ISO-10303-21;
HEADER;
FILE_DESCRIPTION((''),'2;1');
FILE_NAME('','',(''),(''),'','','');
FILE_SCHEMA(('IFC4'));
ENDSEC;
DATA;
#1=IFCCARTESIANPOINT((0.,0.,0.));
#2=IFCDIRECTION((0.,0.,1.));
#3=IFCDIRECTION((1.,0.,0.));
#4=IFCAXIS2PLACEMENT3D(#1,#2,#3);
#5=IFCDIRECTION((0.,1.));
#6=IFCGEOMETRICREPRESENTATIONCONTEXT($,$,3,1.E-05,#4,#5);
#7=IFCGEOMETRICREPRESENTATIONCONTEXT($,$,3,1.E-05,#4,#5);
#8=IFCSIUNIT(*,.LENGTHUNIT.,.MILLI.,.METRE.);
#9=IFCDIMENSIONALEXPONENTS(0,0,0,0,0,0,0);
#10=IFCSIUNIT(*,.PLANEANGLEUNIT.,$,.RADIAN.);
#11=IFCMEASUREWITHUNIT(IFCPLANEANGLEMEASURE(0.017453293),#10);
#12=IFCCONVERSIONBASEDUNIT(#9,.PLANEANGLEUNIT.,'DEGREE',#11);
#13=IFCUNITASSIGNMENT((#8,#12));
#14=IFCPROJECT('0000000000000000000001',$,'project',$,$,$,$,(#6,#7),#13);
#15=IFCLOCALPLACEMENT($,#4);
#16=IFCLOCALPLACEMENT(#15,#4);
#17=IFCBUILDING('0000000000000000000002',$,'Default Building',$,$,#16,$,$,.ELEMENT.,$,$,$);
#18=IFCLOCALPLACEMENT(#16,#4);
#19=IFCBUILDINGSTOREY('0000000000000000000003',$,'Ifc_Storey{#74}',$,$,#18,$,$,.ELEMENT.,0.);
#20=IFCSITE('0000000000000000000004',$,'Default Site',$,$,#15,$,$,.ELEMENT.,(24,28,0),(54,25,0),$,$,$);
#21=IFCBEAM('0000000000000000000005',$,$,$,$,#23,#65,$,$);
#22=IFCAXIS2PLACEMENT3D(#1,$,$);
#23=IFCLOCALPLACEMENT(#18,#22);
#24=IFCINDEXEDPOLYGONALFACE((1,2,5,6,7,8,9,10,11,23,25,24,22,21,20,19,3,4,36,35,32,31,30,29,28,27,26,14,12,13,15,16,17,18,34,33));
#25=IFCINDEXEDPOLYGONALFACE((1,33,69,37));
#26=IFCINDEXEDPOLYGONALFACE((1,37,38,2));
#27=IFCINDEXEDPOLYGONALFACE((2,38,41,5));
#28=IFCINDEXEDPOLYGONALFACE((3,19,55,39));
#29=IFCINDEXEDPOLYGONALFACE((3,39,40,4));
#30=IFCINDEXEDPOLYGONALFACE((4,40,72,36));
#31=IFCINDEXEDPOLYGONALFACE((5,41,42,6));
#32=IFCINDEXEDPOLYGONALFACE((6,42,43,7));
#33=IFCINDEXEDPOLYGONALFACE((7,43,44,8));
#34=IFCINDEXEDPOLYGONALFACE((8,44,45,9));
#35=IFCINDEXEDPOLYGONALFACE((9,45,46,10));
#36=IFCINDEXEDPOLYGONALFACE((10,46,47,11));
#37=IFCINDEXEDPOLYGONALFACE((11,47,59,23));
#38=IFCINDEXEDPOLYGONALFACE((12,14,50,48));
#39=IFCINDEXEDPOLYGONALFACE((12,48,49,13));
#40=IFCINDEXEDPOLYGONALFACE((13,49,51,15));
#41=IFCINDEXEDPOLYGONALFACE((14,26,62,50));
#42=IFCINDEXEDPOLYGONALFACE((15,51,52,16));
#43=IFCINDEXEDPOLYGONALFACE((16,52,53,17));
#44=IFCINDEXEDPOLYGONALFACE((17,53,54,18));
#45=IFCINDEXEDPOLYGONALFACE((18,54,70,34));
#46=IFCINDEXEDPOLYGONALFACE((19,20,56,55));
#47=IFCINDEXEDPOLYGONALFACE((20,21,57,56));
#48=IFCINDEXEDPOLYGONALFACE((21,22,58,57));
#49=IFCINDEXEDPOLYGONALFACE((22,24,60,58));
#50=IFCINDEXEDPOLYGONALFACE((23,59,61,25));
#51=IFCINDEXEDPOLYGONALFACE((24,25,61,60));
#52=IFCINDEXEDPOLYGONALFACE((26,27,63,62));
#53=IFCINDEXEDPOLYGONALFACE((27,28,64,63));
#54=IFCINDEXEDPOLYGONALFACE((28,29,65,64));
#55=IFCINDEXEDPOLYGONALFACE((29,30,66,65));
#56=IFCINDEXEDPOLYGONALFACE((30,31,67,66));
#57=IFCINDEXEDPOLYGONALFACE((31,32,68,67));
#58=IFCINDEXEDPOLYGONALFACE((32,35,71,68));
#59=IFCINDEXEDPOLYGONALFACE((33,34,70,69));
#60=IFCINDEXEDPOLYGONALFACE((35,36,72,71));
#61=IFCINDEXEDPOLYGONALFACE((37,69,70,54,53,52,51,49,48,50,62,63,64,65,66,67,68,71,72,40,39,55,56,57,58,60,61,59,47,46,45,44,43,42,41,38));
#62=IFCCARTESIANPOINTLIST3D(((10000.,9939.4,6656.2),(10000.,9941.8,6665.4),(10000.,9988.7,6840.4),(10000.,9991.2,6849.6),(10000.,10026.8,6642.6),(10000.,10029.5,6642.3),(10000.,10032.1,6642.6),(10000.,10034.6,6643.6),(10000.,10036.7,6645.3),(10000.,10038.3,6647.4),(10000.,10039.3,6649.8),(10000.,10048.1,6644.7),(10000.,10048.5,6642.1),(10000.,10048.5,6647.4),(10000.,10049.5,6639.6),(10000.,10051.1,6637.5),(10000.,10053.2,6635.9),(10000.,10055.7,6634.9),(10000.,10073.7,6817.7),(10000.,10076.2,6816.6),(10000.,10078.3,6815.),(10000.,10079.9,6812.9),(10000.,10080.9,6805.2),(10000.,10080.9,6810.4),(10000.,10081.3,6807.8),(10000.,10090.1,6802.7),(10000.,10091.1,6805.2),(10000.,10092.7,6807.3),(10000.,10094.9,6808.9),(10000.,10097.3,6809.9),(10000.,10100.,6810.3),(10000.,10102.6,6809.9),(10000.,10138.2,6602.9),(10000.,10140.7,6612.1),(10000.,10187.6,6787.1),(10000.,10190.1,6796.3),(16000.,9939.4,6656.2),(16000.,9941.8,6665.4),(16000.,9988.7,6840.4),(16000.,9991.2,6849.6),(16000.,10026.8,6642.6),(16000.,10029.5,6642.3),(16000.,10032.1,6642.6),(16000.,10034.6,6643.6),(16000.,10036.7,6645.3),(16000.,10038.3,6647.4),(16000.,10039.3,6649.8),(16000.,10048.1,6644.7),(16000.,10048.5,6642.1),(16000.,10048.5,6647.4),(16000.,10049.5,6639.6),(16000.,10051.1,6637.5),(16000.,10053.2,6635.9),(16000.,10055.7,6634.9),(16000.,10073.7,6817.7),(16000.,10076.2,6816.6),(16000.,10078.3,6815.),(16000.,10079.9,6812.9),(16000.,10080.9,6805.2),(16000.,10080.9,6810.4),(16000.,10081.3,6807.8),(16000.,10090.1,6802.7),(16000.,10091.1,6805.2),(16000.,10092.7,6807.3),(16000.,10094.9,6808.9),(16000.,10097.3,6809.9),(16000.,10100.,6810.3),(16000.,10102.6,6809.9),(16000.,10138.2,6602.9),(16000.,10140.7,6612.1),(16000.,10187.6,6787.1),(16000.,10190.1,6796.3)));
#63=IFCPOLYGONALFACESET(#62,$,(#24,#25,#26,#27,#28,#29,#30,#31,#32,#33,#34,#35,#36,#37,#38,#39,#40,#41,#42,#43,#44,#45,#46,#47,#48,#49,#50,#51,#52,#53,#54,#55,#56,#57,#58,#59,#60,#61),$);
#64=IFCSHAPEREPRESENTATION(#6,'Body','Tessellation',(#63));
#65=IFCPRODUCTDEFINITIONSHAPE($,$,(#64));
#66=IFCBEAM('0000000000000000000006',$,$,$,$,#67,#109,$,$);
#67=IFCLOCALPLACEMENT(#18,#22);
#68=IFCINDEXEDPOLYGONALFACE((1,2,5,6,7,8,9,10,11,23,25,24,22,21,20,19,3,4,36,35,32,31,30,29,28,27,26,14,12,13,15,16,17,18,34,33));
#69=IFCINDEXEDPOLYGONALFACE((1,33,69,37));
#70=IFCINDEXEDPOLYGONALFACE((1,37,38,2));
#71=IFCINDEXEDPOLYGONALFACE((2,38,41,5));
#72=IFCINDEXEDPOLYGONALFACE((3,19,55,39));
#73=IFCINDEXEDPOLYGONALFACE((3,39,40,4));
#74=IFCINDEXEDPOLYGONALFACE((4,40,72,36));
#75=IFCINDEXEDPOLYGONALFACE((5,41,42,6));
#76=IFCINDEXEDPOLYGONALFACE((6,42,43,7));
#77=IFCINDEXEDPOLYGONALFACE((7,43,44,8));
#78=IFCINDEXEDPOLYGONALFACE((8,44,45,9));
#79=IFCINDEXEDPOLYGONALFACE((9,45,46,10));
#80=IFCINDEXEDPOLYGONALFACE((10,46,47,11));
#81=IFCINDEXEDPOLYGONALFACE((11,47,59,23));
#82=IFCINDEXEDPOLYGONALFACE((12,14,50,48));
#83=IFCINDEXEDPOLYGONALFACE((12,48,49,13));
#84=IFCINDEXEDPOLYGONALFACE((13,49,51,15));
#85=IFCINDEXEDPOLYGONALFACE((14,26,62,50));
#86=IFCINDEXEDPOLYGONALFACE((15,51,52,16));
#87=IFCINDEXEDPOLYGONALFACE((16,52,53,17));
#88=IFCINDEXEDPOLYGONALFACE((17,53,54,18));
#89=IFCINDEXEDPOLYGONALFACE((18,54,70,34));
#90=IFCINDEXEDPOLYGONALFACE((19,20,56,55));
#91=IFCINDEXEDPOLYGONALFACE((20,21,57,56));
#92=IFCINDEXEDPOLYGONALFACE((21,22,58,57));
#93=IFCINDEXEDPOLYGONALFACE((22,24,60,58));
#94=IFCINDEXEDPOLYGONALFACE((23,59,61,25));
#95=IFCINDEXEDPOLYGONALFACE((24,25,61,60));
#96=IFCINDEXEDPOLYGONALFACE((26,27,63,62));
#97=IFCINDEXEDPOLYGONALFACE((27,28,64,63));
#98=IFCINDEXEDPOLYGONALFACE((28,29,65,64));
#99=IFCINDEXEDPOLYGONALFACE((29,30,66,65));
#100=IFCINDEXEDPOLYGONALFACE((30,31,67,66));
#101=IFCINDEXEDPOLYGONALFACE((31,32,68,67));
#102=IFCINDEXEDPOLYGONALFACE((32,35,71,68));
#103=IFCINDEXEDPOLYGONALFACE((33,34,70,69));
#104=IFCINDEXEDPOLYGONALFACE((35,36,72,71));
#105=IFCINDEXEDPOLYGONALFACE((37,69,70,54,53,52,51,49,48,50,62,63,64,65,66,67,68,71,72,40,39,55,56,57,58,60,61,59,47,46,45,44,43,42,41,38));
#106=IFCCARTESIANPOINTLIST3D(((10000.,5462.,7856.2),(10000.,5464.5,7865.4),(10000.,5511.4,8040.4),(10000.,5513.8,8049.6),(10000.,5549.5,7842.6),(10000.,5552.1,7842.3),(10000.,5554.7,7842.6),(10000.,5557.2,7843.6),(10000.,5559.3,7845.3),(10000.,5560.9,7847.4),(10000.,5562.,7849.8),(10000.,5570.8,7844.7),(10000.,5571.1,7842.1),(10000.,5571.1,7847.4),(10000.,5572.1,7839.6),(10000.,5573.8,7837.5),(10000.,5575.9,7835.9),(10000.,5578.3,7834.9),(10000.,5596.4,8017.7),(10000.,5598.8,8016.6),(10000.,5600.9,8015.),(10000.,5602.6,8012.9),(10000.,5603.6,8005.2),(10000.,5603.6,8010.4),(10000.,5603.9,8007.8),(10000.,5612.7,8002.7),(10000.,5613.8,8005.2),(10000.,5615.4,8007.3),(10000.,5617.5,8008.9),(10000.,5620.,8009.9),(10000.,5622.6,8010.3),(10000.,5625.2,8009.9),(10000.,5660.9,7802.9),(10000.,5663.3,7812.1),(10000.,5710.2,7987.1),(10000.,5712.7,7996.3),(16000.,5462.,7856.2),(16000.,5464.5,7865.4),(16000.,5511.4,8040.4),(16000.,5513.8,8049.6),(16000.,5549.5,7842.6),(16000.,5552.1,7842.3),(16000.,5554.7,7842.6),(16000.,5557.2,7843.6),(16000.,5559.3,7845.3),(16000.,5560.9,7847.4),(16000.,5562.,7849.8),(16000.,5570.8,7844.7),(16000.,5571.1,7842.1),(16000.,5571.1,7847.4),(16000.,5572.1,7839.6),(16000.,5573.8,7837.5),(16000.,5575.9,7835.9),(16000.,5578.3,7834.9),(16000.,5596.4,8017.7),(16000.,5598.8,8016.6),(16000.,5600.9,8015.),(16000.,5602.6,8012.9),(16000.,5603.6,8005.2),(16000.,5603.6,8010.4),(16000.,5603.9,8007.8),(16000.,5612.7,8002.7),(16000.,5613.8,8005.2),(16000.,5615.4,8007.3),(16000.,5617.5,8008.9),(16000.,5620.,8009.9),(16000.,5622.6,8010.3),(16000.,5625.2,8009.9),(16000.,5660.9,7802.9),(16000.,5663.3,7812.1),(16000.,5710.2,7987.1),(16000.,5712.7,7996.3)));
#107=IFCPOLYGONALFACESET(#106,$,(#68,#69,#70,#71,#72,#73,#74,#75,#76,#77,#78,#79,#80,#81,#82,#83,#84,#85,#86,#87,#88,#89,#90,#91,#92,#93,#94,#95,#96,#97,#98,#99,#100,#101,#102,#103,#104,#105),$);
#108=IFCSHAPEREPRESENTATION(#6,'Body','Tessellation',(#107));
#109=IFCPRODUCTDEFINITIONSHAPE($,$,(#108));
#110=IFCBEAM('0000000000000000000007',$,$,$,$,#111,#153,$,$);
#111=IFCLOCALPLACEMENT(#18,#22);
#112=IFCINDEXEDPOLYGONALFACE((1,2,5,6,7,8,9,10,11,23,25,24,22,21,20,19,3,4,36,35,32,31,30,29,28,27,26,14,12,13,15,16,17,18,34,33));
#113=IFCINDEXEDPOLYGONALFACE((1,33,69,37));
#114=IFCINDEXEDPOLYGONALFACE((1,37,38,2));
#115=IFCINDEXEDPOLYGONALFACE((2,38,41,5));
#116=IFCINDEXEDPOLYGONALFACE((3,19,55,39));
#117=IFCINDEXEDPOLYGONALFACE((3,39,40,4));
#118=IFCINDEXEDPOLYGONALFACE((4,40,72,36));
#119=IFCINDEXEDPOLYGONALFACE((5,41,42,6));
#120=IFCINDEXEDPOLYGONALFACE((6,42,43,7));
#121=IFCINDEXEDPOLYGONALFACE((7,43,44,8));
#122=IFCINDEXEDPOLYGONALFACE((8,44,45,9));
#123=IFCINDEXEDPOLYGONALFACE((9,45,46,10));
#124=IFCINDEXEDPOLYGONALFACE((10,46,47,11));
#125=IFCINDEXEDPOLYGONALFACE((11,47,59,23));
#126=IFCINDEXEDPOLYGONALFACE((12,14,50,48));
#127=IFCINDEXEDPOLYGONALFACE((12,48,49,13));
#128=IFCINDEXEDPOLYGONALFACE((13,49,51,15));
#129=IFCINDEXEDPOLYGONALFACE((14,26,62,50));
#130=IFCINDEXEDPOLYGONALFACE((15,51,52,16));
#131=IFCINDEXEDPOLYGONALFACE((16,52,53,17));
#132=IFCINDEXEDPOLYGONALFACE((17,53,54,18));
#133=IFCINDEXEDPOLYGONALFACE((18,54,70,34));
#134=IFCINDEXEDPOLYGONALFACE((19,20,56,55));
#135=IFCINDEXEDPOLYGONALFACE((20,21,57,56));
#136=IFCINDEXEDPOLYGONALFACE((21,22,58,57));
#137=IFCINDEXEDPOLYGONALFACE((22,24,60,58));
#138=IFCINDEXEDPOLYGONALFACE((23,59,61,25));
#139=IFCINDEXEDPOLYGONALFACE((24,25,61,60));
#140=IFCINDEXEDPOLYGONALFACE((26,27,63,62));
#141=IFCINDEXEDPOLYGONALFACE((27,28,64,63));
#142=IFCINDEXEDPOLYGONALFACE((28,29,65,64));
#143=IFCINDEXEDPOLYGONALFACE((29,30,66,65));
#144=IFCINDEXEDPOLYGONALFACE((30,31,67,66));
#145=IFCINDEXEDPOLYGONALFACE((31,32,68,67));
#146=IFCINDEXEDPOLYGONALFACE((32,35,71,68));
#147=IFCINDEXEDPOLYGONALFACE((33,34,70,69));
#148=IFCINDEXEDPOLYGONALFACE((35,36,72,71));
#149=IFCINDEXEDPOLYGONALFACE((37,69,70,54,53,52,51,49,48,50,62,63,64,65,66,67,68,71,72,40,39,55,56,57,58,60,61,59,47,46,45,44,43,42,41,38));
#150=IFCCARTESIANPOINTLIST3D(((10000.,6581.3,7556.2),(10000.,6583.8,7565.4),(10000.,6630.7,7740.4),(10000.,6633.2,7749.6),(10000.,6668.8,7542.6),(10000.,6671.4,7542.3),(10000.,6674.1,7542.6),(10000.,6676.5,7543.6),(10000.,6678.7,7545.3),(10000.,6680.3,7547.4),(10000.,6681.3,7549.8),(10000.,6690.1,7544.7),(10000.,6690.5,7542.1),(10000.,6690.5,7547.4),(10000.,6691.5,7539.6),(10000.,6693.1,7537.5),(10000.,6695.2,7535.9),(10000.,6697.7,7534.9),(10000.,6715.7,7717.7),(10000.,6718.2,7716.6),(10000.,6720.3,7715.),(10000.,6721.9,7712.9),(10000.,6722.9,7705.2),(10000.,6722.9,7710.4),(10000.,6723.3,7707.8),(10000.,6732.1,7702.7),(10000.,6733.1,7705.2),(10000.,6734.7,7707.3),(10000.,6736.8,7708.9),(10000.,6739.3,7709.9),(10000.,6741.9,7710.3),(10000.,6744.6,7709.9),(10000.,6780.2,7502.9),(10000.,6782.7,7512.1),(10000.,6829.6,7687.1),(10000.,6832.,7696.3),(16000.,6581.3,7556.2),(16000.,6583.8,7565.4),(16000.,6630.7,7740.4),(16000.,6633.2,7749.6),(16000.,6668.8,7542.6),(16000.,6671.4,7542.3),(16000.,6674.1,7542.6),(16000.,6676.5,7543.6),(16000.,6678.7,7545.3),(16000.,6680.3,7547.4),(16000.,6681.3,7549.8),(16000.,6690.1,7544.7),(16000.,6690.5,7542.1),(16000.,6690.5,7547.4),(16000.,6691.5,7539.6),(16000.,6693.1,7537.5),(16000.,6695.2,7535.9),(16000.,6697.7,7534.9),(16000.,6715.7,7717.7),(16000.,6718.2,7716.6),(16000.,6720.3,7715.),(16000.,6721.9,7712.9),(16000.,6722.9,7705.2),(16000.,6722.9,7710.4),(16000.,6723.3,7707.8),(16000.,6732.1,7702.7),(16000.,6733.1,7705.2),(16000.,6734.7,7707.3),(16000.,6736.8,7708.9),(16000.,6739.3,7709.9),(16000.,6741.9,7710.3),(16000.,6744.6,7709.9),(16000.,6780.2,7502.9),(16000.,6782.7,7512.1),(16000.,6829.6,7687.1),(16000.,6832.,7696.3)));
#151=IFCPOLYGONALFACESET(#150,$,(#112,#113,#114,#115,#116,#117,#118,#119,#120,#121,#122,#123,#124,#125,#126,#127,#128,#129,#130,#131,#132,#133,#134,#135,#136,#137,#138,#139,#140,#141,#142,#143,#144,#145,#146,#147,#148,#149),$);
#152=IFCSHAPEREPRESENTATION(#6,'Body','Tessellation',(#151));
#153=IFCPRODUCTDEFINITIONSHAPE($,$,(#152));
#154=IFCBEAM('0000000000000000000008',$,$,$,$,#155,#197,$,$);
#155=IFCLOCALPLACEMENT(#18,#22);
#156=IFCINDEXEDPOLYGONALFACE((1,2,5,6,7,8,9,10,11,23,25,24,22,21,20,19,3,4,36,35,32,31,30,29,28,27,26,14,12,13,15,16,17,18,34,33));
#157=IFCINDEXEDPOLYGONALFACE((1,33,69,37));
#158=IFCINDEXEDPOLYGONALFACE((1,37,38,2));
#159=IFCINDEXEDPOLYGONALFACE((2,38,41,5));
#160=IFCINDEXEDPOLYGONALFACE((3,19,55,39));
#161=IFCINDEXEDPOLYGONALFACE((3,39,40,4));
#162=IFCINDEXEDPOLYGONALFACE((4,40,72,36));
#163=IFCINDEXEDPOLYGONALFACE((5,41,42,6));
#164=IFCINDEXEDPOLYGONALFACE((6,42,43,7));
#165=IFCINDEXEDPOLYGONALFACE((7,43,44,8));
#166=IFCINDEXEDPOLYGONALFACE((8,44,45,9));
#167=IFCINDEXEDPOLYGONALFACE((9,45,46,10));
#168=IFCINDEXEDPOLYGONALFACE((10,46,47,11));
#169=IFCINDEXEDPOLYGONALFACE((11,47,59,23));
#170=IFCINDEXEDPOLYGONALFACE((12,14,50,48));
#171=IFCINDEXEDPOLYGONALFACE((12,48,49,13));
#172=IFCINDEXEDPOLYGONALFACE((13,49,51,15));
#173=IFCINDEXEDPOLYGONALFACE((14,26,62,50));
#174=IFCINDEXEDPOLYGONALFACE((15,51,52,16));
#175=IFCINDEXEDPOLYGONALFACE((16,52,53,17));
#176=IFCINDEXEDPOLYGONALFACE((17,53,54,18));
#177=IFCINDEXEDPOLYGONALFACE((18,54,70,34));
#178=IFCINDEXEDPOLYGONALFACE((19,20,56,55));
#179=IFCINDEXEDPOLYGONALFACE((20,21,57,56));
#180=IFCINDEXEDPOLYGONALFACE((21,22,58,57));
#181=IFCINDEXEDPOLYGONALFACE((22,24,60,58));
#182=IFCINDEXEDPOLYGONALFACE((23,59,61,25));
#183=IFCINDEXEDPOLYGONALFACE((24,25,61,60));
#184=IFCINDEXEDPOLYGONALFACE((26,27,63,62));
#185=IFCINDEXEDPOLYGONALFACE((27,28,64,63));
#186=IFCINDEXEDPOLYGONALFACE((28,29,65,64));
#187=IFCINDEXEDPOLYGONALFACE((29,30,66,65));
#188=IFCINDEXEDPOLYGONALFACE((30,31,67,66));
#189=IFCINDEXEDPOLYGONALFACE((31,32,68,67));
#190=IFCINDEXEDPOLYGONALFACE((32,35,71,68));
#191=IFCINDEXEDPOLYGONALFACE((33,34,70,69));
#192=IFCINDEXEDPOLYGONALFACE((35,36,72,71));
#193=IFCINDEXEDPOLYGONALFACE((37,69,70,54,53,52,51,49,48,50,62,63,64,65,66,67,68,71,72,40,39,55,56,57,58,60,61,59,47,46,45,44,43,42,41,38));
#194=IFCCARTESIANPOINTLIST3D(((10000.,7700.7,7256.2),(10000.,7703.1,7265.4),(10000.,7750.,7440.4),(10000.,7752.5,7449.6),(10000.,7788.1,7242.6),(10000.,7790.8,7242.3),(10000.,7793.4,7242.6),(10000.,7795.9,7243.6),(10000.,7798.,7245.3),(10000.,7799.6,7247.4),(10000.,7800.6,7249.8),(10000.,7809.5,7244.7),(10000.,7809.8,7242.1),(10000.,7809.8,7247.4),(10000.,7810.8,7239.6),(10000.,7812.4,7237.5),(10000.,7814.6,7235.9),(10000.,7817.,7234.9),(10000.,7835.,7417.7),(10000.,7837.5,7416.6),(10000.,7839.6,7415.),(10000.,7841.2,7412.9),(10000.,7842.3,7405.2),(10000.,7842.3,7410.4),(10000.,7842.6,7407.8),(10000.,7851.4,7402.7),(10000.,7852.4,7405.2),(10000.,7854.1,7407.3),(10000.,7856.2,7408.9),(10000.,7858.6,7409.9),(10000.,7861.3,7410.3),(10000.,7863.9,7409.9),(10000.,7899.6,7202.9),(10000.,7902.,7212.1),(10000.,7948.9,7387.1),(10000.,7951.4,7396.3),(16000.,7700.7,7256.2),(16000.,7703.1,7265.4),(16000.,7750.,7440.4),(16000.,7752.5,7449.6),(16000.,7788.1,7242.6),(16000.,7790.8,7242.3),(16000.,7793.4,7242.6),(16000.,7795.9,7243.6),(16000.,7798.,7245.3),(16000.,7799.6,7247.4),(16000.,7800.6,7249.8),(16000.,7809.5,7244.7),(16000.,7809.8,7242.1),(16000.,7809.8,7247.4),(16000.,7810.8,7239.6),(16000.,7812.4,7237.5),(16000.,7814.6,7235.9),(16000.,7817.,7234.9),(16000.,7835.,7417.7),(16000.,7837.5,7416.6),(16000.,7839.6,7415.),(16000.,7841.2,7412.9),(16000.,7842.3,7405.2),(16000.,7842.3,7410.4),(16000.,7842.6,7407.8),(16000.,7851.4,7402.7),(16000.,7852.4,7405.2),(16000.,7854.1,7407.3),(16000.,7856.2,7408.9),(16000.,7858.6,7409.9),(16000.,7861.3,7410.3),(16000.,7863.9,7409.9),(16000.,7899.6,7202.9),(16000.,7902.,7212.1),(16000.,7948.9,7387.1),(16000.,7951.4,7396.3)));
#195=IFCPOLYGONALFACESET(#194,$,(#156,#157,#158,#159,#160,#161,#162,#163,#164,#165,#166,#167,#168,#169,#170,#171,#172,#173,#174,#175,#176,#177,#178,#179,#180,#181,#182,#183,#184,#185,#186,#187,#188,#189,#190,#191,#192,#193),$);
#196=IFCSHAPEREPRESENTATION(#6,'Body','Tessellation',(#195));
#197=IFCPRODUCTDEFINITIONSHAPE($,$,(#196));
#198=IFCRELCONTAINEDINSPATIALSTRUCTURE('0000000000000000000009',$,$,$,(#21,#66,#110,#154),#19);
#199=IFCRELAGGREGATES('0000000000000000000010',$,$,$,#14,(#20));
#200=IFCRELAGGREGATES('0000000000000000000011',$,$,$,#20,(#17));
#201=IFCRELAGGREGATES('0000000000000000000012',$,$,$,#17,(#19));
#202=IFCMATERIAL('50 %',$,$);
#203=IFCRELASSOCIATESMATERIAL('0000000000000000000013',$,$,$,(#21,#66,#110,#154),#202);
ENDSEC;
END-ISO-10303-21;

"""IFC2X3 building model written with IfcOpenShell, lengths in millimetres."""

from ifc_helpers import new_model, entity, si_unit, converted_unit, direction, frame, origin_with_axes, origin_2d_with_axis, place, context, project, spatial, i_section, extrude, material, element, save


model = new_model("IFC2X3")

# Units and contexts
context_of_model_1 = context(None, 3, precision=1e-05, world=origin_with_axes(), true_north=direction((0.0, 1.0)))
context_of_model_2 = context(None, 3, precision=1e-05, world=origin_with_axes(), true_north=direction((0.0, 1.0)))
ifc_project = project(units=[si_unit("LENGTHUNIT", "METRE", prefix="MILLI"), converted_unit("PLANEANGLEUNIT", "DEGREE", entity("IfcPlaneAngleMeasure", 0.017453293), si_unit("PLANEANGLEUNIT", "RADIAN"), dimensions=[0, 0, 0, 0, 0, 0, 0])], contexts=[context_of_model_1, context_of_model_2])

# Site, building, storey
site_placement = place(None, origin_with_axes())
site = spatial("IfcSite", under=ifc_project, at=site_placement, Name="Default Site", CompositionType="ELEMENT", RefLatitude=(24, 28, 0), RefLongitude=(54, 25, 0))
building_placement = place(site_placement, origin_with_axes())
building = spatial("IfcBuilding", under=site, at=building_placement, Name="Default Building", CompositionType="ELEMENT")
storey_placement = place(building_placement, origin_with_axes())
storey = spatial("IfcBuildingStorey", under=building, at=storey_placement, Name="Ifc_Storey{#74}", CompositionType="ELEMENT", Elevation=0.0)

# Shared definitions
ifc_material_1 = material(Name="50 %")

# Beams
for number, where, z_axis, x_axis in (
    (1, (10000.0, 10064.7, 6726.3), (0.0, 0.258819, 0.965926), (1.0, 0.0, 0.0)),
    (2, (10000.0, 5587.4, 7926.3), (0.0, 0.258819, 0.965926), (1.0, 0.0, 0.0)),
    (3, (10000.0, 6706.7, 7626.3), (0.0, 0.258819, 0.965926), (1.0, 0.0, 0.0)),
    (4, (10000.0, 7826.0, 7326.3), (0.0, 0.258819, 0.965926), (1.0, 0.0, 0.0)),
):
    element("IfcBeam", number, at=place(storey_placement, frame(where, z_axis=z_axis, x_axis=x_axis)), inside=storey, material=ifc_material_1, context=context_of_model_1, shape_type="SweptSolid", body=[
        extrude(i_section(OverallWidth=205.9, OverallDepth=200.2, WebThickness=9.5, FlangeThickness=9.5, FilletRadius=10.2, at=origin_2d_with_axis()), frame((0.0, 0.0, 0.0), z_axis=(1.0, 0.0, 0.0), x_axis=(0.0, 1.0, 0.0)), (0.0, 0.0, 1.0), 6000.0),
    ])

save(model, "model.ifc")
